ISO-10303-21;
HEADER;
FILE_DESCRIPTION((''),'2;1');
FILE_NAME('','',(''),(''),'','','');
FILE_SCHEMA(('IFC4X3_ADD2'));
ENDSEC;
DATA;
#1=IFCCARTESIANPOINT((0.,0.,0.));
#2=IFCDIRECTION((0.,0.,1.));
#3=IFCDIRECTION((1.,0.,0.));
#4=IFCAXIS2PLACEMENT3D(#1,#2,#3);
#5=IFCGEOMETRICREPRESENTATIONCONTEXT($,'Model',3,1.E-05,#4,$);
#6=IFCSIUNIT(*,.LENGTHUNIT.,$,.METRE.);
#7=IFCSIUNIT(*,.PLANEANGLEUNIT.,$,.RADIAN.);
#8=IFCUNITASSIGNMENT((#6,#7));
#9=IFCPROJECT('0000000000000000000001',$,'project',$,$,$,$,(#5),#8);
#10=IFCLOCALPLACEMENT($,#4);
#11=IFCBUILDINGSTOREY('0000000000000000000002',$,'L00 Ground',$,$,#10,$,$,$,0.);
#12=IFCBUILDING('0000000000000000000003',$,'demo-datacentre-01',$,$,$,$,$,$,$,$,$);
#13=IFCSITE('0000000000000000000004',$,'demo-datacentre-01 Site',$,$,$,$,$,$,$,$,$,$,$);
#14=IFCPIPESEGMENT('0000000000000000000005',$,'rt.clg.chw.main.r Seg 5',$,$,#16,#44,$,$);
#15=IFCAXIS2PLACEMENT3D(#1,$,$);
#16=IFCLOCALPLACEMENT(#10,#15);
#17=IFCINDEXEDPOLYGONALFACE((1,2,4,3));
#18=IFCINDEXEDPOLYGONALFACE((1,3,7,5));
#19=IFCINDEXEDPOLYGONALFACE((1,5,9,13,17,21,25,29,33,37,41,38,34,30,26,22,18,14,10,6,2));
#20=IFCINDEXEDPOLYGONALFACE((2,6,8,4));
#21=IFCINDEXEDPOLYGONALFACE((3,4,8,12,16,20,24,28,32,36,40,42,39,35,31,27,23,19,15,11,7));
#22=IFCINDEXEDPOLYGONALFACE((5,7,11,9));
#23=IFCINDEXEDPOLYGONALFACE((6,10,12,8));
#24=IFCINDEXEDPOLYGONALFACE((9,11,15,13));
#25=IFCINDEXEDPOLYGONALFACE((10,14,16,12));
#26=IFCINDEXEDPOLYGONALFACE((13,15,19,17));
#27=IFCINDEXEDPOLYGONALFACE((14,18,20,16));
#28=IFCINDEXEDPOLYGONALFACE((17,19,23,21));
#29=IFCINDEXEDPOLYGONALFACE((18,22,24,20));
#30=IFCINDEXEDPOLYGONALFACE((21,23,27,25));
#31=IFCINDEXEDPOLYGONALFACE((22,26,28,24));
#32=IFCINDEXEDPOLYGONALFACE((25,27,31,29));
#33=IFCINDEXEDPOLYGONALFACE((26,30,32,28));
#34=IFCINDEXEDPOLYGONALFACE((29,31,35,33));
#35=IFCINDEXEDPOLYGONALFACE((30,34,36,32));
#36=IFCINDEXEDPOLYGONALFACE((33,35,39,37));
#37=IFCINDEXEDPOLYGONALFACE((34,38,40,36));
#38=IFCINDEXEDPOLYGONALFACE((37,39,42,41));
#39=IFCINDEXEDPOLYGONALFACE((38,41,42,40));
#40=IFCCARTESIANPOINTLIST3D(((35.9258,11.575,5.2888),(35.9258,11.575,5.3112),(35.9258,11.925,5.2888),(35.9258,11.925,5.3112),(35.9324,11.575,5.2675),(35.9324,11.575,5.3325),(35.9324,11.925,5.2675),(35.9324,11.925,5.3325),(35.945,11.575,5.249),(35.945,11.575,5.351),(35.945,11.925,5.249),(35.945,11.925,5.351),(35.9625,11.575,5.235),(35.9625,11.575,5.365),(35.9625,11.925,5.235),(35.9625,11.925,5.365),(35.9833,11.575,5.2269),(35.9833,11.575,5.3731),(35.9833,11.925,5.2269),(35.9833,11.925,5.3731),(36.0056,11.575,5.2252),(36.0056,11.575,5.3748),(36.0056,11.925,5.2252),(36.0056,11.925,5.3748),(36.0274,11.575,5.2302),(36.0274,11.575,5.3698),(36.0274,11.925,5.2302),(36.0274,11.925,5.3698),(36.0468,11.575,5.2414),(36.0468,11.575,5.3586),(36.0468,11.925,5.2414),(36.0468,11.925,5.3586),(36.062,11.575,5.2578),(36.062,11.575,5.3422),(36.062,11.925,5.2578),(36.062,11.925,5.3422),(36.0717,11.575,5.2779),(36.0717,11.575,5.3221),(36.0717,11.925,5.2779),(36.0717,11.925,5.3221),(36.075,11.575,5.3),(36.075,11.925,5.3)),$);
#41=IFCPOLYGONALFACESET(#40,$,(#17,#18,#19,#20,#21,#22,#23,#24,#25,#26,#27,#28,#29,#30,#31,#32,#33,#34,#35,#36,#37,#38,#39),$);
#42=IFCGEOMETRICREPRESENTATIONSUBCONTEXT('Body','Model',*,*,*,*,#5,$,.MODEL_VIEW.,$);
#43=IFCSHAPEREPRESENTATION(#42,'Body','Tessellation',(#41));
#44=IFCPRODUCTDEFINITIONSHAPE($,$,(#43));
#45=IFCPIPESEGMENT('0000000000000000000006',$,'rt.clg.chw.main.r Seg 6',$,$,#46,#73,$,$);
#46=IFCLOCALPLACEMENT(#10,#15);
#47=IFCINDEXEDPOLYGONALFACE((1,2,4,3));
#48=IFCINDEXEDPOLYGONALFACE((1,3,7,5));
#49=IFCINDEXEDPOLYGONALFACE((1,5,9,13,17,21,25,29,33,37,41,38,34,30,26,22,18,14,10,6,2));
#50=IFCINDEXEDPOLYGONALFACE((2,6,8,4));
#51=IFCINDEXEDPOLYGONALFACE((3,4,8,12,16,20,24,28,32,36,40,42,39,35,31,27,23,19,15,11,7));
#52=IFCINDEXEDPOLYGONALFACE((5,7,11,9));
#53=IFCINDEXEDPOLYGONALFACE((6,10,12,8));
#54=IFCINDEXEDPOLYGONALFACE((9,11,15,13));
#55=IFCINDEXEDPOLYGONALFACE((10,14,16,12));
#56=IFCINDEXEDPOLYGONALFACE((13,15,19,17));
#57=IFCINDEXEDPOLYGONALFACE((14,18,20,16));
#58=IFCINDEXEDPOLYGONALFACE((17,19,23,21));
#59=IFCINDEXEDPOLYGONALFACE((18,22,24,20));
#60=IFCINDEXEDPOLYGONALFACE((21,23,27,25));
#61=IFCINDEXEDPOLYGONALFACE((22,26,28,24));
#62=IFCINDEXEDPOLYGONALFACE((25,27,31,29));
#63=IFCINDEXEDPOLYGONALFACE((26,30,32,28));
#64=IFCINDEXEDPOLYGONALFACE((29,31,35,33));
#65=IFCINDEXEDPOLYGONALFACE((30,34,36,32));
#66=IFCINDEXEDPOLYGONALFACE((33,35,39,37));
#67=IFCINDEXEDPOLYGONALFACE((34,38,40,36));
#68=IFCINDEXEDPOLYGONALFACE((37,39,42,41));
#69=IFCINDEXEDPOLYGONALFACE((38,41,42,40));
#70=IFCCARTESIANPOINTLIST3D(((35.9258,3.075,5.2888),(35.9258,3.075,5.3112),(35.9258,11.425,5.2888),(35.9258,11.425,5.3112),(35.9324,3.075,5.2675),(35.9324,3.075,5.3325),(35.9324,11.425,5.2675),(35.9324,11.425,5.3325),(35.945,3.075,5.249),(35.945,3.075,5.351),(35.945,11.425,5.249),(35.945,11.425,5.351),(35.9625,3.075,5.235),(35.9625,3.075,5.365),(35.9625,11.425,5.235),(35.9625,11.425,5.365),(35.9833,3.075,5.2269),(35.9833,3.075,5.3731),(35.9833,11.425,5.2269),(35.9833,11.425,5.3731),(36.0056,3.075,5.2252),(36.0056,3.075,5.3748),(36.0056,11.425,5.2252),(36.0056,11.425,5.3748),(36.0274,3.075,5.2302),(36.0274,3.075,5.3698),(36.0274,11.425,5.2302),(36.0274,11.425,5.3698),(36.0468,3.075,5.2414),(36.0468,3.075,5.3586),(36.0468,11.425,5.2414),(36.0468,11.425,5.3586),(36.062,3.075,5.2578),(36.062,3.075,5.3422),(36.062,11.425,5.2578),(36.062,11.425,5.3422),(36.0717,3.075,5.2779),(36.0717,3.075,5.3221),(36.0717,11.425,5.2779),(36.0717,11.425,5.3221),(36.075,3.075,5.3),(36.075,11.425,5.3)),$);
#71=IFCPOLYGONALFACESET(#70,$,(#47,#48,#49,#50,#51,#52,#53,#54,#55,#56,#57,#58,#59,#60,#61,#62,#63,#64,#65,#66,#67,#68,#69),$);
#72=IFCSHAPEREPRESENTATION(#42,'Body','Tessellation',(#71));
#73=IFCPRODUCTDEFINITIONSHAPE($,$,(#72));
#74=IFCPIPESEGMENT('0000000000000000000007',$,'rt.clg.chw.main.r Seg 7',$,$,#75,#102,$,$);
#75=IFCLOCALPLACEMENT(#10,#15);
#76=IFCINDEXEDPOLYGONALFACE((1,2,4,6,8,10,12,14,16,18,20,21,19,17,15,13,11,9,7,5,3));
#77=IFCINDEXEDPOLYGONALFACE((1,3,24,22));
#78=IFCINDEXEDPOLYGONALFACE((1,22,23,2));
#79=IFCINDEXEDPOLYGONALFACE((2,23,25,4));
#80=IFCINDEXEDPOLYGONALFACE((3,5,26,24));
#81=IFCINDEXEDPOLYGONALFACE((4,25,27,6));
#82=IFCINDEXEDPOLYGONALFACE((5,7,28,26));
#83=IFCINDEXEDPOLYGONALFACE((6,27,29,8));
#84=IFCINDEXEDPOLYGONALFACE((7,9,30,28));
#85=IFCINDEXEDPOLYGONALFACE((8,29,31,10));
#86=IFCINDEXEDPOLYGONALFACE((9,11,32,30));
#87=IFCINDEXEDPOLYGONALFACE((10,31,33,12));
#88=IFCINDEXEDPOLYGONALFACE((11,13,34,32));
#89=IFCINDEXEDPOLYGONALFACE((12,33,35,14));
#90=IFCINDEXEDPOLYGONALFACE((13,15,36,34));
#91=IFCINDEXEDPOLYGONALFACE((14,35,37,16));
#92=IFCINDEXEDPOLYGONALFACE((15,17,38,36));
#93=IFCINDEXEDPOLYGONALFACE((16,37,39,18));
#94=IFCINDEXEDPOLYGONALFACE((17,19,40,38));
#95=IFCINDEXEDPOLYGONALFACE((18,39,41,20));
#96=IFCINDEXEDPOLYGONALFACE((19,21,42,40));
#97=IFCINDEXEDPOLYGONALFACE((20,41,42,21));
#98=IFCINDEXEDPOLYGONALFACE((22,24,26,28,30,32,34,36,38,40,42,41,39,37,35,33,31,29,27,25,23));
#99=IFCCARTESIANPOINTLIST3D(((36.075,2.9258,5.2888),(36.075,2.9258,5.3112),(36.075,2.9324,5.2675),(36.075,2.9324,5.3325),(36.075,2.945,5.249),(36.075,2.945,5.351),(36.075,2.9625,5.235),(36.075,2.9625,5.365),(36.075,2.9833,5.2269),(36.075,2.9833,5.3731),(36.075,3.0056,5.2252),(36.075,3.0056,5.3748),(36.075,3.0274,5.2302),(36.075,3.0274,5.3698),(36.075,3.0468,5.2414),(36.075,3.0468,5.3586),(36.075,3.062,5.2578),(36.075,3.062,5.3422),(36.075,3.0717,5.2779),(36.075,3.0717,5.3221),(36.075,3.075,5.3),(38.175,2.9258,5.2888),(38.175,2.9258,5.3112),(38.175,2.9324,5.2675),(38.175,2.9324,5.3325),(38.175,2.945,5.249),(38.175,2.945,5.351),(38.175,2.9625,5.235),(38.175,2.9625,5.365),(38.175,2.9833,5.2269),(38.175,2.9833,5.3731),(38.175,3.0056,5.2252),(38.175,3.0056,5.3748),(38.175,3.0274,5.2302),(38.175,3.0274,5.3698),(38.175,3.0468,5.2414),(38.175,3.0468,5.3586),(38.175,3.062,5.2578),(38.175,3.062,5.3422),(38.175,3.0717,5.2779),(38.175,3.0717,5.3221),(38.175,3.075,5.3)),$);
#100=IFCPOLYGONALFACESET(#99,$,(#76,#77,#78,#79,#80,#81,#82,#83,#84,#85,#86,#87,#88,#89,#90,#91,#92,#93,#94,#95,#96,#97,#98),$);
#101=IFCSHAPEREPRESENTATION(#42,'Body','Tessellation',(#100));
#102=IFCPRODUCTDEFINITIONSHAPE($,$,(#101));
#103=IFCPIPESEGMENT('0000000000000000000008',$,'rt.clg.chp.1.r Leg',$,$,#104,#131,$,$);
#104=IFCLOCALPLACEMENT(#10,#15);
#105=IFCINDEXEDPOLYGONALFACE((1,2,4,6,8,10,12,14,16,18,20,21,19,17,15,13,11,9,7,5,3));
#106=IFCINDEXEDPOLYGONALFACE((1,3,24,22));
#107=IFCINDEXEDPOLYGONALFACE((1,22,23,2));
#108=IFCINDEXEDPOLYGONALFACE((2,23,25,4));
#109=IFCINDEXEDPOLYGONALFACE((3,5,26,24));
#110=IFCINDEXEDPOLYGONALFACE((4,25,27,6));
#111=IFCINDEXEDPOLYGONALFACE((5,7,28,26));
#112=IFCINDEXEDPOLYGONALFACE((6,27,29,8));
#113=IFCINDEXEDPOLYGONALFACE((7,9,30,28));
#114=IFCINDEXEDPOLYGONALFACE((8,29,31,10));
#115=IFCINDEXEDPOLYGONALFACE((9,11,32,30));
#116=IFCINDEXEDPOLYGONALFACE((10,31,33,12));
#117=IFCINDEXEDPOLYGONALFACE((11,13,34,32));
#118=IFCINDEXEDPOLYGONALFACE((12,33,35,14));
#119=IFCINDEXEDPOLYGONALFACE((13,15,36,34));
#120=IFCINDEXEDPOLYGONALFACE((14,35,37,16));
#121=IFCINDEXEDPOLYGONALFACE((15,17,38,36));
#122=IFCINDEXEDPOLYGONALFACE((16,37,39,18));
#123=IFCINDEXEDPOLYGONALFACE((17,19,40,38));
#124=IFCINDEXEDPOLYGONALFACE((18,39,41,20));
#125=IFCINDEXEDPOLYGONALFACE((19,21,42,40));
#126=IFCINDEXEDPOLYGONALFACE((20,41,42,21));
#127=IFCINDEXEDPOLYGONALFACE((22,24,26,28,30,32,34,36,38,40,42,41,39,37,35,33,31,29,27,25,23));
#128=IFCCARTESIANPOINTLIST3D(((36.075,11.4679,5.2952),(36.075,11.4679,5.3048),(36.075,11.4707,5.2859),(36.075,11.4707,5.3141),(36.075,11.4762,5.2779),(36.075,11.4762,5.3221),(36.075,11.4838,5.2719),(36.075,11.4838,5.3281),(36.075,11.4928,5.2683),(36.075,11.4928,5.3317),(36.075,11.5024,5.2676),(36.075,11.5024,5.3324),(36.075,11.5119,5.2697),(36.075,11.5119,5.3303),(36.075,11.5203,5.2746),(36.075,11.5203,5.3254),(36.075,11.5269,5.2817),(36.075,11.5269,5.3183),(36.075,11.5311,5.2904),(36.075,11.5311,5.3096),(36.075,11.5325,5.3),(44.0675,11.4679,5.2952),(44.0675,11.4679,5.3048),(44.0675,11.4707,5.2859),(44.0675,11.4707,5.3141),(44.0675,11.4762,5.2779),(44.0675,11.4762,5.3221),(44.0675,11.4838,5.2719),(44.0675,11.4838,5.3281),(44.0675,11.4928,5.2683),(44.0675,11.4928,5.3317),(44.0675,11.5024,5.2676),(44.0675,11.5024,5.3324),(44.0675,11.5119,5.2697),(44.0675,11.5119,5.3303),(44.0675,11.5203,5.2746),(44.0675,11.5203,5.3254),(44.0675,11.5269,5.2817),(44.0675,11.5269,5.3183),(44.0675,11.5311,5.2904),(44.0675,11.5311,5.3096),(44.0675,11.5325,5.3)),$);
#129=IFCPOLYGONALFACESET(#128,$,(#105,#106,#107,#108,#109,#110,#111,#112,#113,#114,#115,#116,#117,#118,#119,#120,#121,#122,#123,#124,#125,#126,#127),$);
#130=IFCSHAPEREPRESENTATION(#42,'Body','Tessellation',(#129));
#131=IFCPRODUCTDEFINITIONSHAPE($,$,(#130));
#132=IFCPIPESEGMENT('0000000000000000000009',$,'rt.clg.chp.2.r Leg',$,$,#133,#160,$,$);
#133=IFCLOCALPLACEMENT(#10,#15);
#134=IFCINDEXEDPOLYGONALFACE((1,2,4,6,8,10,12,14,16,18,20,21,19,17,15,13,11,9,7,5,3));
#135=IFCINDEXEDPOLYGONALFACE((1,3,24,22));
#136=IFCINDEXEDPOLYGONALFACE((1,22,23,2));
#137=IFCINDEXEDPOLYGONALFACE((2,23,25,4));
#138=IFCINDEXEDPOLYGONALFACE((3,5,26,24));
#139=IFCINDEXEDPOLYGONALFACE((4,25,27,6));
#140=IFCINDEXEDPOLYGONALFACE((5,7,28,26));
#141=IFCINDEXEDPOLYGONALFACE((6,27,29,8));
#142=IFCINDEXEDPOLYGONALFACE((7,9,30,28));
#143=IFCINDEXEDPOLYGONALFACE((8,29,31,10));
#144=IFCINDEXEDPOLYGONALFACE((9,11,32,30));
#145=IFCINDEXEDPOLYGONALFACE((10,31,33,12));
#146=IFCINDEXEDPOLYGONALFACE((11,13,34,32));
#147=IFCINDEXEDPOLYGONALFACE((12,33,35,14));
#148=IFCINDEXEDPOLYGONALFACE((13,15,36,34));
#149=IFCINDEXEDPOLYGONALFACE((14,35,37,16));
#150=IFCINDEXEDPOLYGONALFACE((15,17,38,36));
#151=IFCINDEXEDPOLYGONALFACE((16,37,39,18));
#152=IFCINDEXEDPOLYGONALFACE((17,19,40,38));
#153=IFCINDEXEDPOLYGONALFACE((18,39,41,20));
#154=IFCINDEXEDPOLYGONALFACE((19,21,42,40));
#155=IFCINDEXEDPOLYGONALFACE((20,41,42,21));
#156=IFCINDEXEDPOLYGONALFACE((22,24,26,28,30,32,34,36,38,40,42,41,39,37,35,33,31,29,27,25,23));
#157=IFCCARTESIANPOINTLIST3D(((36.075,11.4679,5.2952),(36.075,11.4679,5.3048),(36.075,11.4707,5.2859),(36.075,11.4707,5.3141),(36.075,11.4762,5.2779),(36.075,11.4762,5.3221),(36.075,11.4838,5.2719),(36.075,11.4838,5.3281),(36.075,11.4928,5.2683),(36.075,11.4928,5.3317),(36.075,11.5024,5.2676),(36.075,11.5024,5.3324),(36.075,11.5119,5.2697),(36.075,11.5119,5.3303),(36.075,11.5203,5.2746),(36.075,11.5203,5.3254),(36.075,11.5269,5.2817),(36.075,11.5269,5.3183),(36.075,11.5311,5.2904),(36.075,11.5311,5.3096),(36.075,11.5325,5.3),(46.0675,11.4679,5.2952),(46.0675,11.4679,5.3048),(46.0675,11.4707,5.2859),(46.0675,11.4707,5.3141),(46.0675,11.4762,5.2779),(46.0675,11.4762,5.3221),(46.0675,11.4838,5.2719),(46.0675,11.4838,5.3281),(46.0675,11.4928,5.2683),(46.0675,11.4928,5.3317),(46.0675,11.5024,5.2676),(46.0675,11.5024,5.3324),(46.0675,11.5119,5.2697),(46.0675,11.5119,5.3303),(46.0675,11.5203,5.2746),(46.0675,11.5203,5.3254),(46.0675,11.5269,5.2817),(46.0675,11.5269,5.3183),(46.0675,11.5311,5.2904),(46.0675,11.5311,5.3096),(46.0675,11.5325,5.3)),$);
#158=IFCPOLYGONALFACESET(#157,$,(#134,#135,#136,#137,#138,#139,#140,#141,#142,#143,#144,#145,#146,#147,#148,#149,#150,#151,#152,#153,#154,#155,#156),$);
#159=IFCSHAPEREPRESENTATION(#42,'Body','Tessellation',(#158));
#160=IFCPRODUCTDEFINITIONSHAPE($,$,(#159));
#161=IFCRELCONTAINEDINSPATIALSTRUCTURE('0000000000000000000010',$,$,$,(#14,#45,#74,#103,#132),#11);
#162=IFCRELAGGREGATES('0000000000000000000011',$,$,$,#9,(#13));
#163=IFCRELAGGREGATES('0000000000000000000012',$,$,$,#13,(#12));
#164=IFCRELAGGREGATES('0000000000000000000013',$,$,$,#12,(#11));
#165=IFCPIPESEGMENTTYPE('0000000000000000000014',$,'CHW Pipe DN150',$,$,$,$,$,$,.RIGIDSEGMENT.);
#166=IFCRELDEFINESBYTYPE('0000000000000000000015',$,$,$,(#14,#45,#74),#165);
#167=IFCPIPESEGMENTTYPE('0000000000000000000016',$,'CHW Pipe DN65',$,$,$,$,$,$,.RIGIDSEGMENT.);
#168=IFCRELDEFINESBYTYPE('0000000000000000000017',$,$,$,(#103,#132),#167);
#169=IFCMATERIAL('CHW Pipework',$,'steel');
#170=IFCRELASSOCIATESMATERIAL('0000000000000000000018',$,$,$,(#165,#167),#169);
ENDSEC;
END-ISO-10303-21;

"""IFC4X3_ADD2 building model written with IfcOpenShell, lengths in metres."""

from ifc_helpers import new_model, si_unit, frame, origin_with_axes, place, context, subcontext, project, spatial, circle, extrude, material, type_object, element, save


model = new_model("IFC4X3_ADD2")

# Units and contexts
model_context = context("Model", 3, precision=1e-05, world=origin_with_axes())
body_context = subcontext(model_context, "Body", "Model", "MODEL_VIEW")
ifc_project = project(units=[si_unit("LENGTHUNIT", "METRE"), si_unit("PLANEANGLEUNIT", "RADIAN")], contexts=[model_context])

# Site, building, storey
site = spatial("IfcSite", under=ifc_project, Name="demo-datacentre-01 Site")
building = spatial("IfcBuilding", under=site, Name="demo-datacentre-01")
storey_placement = place(None, origin_with_axes())
storey = spatial("IfcBuildingStorey", under=building, at=storey_placement, Name="L00 Ground", Elevation=0.0)

# Shared definitions
ifc_material_1 = material(Name="CHW Pipework", Category="steel")

# Pipe segments
pipe_segment_type_1 = type_object("IfcPipeSegmentType", Name="CHW Pipe DN150", PredefinedType="RIGIDSEGMENT", material=ifc_material_1)
pipe_segment_1_placement = place(storey_placement, frame((36.0, 11.925, 5.3), z_axis=(0.0, -1.0, 0.0), x_axis=(1.0, 0.0, 0.0)))
element("IfcPipeSegment", 1, at=pipe_segment_1_placement, inside=storey, type_object=pipe_segment_type_1, Name="rt.clg.chw.main.r Seg 5", context=body_context, shape_type="SweptSolid", body=[
    extrude(circle(Radius=0.075), origin_with_axes(), (0.0, 0.0, 1.0), 0.35),
])
pipe_segment_2_placement = place(storey_placement, frame((36.0, 11.425, 5.3), z_axis=(0.0, -1.0, 0.0), x_axis=(1.0, 0.0, 0.0)))
element("IfcPipeSegment", 2, at=pipe_segment_2_placement, inside=storey, type_object=pipe_segment_type_1, Name="rt.clg.chw.main.r Seg 6", context=body_context, shape_type="SweptSolid", body=[
    extrude(circle(Radius=0.075), origin_with_axes(), (0.0, 0.0, 1.0), 8.35),
])
pipe_segment_3_placement = place(storey_placement, frame((36.075, 3.0, 5.3), z_axis=(1.0, 0.0, 0.0), x_axis=(0.0, 1.0, 0.0)))
element("IfcPipeSegment", 3, at=pipe_segment_3_placement, inside=storey, type_object=pipe_segment_type_1, Name="rt.clg.chw.main.r Seg 7", context=body_context, shape_type="SweptSolid", body=[
    extrude(circle(Radius=0.075), origin_with_axes(), (0.0, 0.0, 1.0), 2.1),
])
pipe_segment_type_2 = type_object("IfcPipeSegmentType", Name="CHW Pipe DN65", PredefinedType="RIGIDSEGMENT", material=ifc_material_1)
pipe_segment_4_placement = place(storey_placement, frame((36.075, 11.5, 5.3), z_axis=(1.0, 0.0, 0.0), x_axis=(0.0, 1.0, 0.0)))
element("IfcPipeSegment", 4, at=pipe_segment_4_placement, inside=storey, type_object=pipe_segment_type_2, Name="rt.clg.chp.1.r Leg", context=body_context, shape_type="SweptSolid", body=[
    extrude(circle(Radius=0.0325), origin_with_axes(), (0.0, 0.0, 1.0), 7.9925),
])
pipe_segment_5_placement = place(storey_placement, frame((36.075, 11.5, 5.3), z_axis=(1.0, 0.0, 0.0), x_axis=(0.0, 1.0, 0.0)))
element("IfcPipeSegment", 5, at=pipe_segment_5_placement, inside=storey, type_object=pipe_segment_type_2, Name="rt.clg.chp.2.r Leg", context=body_context, shape_type="SweptSolid", body=[
    extrude(circle(Radius=0.0325), origin_with_axes(), (0.0, 0.0, 1.0), 9.9925),
])

save(model, "model.ifc")
